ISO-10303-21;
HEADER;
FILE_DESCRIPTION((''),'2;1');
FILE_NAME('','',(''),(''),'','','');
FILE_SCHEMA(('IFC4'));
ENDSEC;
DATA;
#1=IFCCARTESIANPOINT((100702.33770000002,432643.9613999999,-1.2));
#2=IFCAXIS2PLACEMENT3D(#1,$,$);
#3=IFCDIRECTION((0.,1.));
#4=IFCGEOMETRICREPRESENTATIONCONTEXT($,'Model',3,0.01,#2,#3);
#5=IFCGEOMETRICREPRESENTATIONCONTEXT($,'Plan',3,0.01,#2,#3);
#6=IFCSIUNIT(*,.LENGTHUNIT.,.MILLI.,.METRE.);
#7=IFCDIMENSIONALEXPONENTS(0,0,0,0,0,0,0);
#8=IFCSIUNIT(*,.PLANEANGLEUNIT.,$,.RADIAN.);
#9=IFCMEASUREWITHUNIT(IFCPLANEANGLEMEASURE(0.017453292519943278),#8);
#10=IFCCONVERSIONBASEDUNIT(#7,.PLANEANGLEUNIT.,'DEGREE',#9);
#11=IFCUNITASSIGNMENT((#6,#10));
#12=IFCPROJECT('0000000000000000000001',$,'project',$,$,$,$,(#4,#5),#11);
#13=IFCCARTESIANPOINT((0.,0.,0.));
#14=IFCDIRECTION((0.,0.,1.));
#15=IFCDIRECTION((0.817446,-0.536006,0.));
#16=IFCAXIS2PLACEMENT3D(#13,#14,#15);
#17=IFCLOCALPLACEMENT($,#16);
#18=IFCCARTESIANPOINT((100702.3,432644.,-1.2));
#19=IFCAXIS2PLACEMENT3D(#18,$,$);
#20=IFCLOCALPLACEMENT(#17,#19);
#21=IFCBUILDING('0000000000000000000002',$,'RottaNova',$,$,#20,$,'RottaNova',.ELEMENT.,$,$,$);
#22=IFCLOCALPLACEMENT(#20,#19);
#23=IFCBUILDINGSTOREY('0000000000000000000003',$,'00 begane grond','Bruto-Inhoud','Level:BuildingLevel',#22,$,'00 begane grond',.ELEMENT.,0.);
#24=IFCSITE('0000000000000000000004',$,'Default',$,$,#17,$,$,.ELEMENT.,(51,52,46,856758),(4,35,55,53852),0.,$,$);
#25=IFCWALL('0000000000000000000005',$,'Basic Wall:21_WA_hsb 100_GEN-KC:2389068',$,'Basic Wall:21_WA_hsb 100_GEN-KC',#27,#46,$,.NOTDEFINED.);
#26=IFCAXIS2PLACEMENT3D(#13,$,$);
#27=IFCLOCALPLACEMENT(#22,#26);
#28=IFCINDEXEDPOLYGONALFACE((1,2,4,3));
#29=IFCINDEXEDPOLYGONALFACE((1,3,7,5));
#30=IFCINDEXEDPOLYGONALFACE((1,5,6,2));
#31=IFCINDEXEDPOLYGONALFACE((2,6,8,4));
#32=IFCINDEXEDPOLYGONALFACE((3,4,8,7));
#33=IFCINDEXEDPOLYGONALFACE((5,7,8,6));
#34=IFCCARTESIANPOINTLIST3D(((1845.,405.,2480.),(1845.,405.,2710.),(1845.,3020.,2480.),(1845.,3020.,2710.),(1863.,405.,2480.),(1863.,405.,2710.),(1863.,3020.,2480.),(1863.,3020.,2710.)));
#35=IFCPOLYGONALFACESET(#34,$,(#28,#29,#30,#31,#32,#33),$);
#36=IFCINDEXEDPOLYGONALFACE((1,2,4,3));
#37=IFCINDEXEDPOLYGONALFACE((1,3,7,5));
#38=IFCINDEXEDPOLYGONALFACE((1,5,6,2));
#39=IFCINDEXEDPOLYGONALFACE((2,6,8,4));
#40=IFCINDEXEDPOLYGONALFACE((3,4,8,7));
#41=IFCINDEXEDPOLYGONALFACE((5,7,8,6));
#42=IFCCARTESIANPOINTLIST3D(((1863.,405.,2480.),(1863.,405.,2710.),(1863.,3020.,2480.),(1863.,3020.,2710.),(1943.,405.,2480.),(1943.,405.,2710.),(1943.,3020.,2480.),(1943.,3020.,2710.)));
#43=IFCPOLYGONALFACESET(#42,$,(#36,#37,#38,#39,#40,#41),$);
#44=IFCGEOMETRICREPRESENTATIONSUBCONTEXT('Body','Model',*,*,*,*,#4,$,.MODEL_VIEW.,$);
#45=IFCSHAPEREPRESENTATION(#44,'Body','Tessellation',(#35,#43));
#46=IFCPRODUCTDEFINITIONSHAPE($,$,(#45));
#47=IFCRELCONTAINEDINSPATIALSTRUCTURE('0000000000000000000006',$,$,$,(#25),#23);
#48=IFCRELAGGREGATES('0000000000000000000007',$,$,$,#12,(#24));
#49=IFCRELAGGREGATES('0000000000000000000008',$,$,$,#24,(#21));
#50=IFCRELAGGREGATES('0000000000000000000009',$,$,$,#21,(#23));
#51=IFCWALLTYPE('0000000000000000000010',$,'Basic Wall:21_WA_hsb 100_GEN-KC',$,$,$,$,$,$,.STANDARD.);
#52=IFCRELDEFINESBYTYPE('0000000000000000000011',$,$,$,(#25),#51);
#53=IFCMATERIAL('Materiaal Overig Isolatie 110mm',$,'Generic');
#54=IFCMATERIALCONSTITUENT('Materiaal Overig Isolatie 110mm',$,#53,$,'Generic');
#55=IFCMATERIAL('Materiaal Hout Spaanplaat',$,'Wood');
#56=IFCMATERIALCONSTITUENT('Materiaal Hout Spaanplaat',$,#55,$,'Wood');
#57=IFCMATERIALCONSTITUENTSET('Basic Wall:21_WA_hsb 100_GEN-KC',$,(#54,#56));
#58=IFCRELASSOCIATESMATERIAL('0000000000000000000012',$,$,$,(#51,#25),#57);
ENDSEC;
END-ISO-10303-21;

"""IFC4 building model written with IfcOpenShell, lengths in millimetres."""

from ifc_helpers import new_model, entity, si_unit, converted_unit, direction, frame, place, context, subcontext, project, spatial, indexed_curve, outline, extrude, material, constituent, constituent_set, type_object, element, save


model = new_model("IFC4")

# Units and contexts
model_context = context("Model", 3, precision=0.01, world=frame((100702.33770000002, 432643.9613999999, -1.2)), true_north=direction((0.0, 1.0)))
plan_context = context("Plan", 3, precision=0.01, world=frame((100702.33770000002, 432643.9613999999, -1.2)), true_north=direction((0.0, 1.0)))
body_context = subcontext(model_context, "Body", "Model", "MODEL_VIEW")
ifc_project = project(units=[si_unit("LENGTHUNIT", "METRE", prefix="MILLI"), converted_unit("PLANEANGLEUNIT", "DEGREE", entity("IfcPlaneAngleMeasure", 0.017453292519943278), si_unit("PLANEANGLEUNIT", "RADIAN"), dimensions=[0, 0, 0, 0, 0, 0, 0])], contexts=[model_context, plan_context])

# Site, building, storey
site_placement = place(None, frame((0.0, 0.0, 0.0), z_axis=(0.0, 0.0, 1.0), x_axis=(0.817446, -0.536006, 0.0)))
site = spatial("IfcSite", under=ifc_project, at=site_placement, Name="Default", CompositionType="ELEMENT", RefLatitude=(51, 52, 46, 856758), RefLongitude=(4, 35, 55, 53852), RefElevation=0.0)
building_placement = place(site_placement, frame((100702.3, 432644.0, -1.2)))
building = spatial("IfcBuilding", under=site, at=building_placement, Name="RottaNova", LongName="RottaNova", CompositionType="ELEMENT")
storey_placement = place(building_placement, frame((100702.3, 432644.0, -1.2)))
storey = spatial("IfcBuildingStorey", under=building, at=storey_placement, Name="00 begane grond", Description="Bruto-Inhoud", ObjectType="Level:BuildingLevel", LongName="00 begane grond", CompositionType="ELEMENT", Elevation=0.0)

# Wall
ifc_material_1 = material(Name="Materiaal Overig Isolatie 110mm", Category="Generic")
ifc_constituent_1 = constituent(ifc_material_1, Name="Materiaal Overig Isolatie 110mm", Category="Generic")
ifc_material_2 = material(Name="Materiaal Hout Spaanplaat", Category="Wood")
ifc_constituent_2 = constituent(ifc_material_2, Name="Materiaal Hout Spaanplaat", Category="Wood")
ifc_constituent_set = constituent_set(constituents=[ifc_constituent_1, ifc_constituent_2], Name="Basic Wall:21_WA_hsb 100_GEN-KC")
wall_type_1 = type_object("IfcWallType", Name="Basic Wall:21_WA_hsb 100_GEN-KC", PredefinedType="STANDARD", material=ifc_constituent_set)
wall_1_placement = place(storey_placement, frame((1894.0, 3020.0, 2480.0), z_axis=(0.0, 0.0, 1.0), x_axis=(0.0, -1.0, 0.0)))
element("IfcWall", 1, at=wall_1_placement, inside=storey, type_object=wall_type_1, material=ifc_constituent_set, Name="Basic Wall:21_WA_hsb 100_GEN-KC:2389068", ObjectType="Basic Wall:21_WA_hsb 100_GEN-KC", PredefinedType="NOTDEFINED", context=body_context, shape_type="SweptSolid", body=[
    extrude(outline(indexed_curve([(-9.0, -1307.5), (9.0, -1307.5), (9.0, 1307.5), (-9.0, 1307.5), (-9.0, -1307.5)], self_intersect=False)), frame((1307.5, -40.0, 0.0), z_axis=(0.0, 0.0, 1.0), x_axis=(0.0, 1.0, 0.0)), (0.0, 0.0, 1.0), 230.0),
    extrude(outline(indexed_curve([(-40.0, -1307.5), (40.0, -1307.5), (40.0, 1307.5), (-40.0, 1307.5), (-40.0, -1307.5)], self_intersect=False)), frame((1307.5, 9.0, 0.0), z_axis=(0.0, 0.0, 1.0), x_axis=(0.0, -1.0, 0.0)), (0.0, 0.0, 1.0), 230.0),
])

save(model, "model.ifc")
